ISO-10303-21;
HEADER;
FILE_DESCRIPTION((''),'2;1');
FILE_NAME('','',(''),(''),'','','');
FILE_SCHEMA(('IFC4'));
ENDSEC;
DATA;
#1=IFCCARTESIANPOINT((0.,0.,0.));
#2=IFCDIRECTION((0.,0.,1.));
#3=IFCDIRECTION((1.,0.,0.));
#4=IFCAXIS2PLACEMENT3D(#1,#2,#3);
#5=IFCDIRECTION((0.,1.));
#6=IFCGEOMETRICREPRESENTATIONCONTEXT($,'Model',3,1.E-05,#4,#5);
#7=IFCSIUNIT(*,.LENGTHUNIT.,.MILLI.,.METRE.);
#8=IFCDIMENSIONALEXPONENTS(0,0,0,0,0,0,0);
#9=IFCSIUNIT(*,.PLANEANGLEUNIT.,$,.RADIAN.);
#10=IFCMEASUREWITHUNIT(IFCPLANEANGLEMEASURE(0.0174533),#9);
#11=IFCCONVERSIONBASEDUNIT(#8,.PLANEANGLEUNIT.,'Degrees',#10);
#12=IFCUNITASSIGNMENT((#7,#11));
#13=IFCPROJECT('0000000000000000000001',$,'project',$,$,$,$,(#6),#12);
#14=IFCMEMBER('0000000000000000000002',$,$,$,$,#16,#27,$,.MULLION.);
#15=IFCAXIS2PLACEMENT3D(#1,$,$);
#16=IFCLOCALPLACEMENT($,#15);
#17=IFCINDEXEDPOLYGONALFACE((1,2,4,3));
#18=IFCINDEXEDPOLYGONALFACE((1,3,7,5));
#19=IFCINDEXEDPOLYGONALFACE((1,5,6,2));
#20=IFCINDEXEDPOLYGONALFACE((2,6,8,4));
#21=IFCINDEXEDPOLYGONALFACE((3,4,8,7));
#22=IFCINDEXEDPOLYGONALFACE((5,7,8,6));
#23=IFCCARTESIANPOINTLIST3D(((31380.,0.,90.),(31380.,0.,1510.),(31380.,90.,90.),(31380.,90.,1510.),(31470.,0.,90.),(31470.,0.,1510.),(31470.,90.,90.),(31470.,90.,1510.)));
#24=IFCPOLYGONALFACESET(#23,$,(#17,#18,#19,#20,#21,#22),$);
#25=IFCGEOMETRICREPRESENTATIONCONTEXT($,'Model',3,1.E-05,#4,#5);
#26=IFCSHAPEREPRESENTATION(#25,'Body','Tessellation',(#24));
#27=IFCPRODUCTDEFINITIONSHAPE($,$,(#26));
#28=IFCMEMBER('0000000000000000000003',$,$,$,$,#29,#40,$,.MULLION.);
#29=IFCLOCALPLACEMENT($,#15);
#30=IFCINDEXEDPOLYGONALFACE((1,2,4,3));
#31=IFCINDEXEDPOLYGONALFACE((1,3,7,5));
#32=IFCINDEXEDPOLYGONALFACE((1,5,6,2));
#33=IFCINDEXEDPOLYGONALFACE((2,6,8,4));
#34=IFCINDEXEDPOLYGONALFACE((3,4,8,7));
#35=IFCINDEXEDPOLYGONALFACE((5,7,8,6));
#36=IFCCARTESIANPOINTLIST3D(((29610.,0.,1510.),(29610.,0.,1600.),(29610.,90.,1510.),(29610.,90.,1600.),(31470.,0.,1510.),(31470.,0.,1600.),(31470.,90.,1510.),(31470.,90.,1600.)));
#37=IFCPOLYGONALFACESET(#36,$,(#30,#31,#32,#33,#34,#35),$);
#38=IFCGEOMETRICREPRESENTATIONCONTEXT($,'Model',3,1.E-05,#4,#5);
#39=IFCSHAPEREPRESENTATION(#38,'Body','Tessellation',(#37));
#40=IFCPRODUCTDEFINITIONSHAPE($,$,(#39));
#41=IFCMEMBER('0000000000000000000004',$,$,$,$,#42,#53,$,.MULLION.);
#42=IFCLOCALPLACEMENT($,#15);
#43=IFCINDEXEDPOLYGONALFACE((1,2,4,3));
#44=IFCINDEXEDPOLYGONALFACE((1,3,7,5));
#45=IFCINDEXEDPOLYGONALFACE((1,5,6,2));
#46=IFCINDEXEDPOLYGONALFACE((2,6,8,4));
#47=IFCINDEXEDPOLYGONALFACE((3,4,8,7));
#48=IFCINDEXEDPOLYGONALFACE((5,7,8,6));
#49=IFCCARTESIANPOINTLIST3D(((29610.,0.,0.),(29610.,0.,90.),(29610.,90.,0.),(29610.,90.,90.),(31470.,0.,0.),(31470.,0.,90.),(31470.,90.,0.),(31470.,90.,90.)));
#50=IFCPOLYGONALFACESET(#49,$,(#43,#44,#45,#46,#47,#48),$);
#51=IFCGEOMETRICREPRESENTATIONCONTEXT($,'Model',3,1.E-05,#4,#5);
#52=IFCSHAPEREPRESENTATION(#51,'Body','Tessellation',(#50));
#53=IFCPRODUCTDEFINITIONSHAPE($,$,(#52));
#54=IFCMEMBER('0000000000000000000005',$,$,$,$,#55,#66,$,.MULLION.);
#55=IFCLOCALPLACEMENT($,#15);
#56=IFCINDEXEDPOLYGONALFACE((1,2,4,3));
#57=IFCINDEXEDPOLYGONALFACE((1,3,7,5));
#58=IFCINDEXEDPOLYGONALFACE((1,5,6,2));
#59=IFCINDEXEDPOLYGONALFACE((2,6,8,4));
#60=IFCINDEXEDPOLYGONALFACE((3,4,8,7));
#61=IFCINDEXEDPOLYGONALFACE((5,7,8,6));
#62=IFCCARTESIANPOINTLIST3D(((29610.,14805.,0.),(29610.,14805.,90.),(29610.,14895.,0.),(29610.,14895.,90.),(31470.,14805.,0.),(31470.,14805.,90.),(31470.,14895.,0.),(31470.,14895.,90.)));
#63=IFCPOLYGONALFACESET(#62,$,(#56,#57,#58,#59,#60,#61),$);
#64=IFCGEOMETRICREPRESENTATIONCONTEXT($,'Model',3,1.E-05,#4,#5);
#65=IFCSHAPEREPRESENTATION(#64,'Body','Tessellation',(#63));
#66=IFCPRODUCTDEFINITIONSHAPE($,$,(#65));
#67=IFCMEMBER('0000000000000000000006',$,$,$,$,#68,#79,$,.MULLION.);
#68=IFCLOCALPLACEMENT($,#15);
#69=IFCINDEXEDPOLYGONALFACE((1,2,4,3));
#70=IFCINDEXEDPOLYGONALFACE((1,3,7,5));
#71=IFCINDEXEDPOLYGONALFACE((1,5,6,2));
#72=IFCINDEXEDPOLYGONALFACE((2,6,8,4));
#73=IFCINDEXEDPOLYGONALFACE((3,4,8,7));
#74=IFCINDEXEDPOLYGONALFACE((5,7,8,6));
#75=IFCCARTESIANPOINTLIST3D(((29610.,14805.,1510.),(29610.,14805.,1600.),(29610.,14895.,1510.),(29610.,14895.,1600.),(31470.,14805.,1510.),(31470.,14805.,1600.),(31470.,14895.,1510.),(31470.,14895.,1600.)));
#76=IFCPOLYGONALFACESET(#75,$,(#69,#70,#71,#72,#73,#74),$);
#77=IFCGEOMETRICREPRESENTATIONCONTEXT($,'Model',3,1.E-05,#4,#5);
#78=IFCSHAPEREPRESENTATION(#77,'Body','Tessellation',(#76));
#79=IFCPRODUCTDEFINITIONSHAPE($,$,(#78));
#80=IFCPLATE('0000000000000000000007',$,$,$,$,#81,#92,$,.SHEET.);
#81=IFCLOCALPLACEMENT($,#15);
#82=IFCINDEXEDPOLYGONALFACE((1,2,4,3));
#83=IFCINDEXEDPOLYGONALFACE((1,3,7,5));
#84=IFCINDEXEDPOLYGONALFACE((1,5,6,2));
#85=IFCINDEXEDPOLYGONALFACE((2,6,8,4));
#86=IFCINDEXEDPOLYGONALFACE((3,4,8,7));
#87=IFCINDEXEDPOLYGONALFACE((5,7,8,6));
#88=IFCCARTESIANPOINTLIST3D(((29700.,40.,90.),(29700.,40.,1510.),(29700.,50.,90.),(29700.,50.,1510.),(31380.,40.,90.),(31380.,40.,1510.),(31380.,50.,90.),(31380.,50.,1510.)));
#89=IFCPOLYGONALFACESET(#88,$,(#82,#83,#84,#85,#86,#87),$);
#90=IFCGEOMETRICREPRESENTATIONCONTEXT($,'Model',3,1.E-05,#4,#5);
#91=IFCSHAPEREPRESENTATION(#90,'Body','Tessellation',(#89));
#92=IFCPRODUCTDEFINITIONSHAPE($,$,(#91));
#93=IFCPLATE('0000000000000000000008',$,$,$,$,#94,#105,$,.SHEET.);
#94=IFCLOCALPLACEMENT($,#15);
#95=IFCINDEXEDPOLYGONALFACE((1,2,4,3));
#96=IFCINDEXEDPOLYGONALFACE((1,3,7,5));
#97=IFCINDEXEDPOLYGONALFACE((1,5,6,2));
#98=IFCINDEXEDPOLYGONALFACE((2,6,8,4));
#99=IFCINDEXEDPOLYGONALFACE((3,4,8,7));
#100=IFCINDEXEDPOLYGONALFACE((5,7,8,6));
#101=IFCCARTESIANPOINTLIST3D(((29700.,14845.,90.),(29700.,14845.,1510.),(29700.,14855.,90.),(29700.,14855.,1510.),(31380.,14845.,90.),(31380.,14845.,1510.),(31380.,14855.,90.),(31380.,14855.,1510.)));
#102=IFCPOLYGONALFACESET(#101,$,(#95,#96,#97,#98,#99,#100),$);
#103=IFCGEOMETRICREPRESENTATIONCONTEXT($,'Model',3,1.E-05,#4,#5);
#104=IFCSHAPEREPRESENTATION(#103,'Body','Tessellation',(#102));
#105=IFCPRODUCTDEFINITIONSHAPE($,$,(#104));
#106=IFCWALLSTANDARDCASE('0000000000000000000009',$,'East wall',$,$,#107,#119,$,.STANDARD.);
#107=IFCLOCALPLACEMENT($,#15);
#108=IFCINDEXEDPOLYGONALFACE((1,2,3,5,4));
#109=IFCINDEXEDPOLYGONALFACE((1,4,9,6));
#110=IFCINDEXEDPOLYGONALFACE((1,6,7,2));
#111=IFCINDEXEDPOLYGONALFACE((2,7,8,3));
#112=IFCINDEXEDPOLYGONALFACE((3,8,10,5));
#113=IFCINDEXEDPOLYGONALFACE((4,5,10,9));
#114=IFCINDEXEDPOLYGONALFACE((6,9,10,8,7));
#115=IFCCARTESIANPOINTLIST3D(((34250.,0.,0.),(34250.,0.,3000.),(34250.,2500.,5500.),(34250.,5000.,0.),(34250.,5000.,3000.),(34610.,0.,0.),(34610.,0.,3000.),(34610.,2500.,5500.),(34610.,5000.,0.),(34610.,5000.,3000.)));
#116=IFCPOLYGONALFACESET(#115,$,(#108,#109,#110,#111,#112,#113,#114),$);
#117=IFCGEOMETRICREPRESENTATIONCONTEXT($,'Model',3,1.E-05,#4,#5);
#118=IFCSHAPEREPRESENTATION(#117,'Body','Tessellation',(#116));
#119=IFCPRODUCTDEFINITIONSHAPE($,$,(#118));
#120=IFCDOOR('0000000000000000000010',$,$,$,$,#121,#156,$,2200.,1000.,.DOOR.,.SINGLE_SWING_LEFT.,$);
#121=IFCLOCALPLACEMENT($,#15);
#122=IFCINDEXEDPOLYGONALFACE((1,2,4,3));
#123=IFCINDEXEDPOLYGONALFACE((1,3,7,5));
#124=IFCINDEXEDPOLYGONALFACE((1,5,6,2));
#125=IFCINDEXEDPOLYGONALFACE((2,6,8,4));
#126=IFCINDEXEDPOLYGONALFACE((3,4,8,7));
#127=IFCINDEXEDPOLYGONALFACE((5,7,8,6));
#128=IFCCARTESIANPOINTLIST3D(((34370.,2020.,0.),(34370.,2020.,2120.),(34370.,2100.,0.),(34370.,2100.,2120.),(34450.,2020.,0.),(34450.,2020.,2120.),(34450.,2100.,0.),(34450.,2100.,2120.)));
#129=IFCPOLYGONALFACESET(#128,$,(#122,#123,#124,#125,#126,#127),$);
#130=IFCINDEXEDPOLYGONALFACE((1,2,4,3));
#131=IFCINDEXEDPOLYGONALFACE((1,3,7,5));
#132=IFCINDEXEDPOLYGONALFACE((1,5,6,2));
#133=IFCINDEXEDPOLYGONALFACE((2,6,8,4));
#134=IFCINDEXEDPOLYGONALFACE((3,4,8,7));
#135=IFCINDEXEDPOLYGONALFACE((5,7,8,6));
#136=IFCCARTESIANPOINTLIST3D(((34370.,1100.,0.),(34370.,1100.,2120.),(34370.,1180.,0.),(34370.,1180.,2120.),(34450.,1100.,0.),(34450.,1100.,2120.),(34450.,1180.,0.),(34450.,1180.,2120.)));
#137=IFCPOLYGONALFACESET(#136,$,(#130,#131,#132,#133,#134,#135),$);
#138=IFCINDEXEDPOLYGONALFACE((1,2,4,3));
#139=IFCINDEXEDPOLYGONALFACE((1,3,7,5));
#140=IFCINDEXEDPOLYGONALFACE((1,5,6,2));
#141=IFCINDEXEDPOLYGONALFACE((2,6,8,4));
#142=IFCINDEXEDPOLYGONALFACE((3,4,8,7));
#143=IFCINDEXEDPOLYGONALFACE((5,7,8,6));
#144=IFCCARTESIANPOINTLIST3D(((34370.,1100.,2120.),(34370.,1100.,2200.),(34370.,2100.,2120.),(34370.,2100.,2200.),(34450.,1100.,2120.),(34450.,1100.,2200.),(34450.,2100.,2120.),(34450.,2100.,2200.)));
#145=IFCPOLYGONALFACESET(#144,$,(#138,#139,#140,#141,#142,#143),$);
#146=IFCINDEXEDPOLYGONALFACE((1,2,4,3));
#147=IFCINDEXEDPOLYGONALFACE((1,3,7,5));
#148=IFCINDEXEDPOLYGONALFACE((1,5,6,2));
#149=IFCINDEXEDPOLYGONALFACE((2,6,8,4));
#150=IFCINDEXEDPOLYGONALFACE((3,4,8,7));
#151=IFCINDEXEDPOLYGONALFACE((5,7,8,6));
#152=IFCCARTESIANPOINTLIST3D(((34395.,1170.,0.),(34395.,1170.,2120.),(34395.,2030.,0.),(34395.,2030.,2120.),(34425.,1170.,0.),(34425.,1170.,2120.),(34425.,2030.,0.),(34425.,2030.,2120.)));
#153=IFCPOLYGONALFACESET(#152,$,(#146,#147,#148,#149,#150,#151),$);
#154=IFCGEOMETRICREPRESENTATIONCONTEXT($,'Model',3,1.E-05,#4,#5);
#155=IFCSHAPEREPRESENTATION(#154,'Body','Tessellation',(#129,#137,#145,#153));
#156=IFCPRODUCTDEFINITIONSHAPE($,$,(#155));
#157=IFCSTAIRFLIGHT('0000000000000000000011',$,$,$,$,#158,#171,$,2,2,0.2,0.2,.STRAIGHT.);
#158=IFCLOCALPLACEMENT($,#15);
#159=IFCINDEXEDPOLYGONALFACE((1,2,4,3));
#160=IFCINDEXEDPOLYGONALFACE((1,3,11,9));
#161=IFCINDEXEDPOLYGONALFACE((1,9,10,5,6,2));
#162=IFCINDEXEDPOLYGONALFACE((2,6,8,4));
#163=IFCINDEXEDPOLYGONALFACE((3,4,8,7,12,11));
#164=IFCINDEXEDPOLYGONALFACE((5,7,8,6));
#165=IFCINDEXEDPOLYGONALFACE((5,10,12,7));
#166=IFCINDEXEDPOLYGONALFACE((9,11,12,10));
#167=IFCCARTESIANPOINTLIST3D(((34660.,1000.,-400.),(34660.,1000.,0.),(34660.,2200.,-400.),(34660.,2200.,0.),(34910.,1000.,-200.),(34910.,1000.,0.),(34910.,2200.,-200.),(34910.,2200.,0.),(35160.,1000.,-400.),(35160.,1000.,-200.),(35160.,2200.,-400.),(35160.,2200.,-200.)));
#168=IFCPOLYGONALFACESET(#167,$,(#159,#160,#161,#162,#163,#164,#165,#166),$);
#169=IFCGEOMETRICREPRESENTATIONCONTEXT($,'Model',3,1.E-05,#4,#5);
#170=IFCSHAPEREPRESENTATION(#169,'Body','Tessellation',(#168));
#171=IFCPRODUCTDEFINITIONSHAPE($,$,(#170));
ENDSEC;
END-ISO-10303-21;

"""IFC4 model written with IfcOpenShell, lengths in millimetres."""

from ifc_helpers import new_model, entity, si_unit, converted_unit, direction, frame, origin_with_axes, place, context, project, polyline, outline, extrude, clip, halfspace, source, transform, mapped, element, save


model = new_model("IFC4")

# Units and contexts
model_context_1 = context("Model", 3, precision=1e-05, world=origin_with_axes(), true_north=direction((0.0, 1.0)))
model_context_2 = context("Model", 3, precision=1e-05, world=origin_with_axes(), true_north=direction((0.0, 1.0)))
model_context_3 = context("Model", 3, precision=1e-05, world=origin_with_axes(), true_north=direction((0.0, 1.0)))
model_context_4 = context("Model", 3, precision=1e-05, world=origin_with_axes(), true_north=direction((0.0, 1.0)))
model_context_5 = context("Model", 3, precision=1e-05, world=origin_with_axes(), true_north=direction((0.0, 1.0)))
model_context_6 = context("Model", 3, precision=1e-05, world=origin_with_axes(), true_north=direction((0.0, 1.0)))
model_context_7 = context("Model", 3, precision=1e-05, world=origin_with_axes(), true_north=direction((0.0, 1.0)))
model_context_8 = context("Model", 3, precision=1e-05, world=origin_with_axes(), true_north=direction((0.0, 1.0)))
model_context_9 = context("Model", 3, precision=1e-05, world=origin_with_axes(), true_north=direction((0.0, 1.0)))
model_context_10 = context("Model", 3, precision=1e-05, world=origin_with_axes(), true_north=direction((0.0, 1.0)))
model_context_11 = context("Model", 3, precision=1e-05, world=origin_with_axes(), true_north=direction((0.0, 1.0)))
ifc_project = project(units=[si_unit("LENGTHUNIT", "METRE", prefix="MILLI"), converted_unit("PLANEANGLEUNIT", "Degrees", entity("IfcPlaneAngleMeasure", 0.0174533), si_unit("PLANEANGLEUNIT", "RADIAN"), dimensions=[0, 0, 0, 0, 0, 0, 0])], contexts=[model_context_1])

# Members
shared_shape_1 = source(origin_with_axes(), model_context_3, "Body", "SweptSolid", [
    extrude(outline(polyline([(-45.0, -45.0), (45.0, -45.0), (45.0, 45.0), (-45.0, 45.0), (-45.0, -45.0), (-45.0, -45.0)])), origin_with_axes(), (0.0, 0.0, 1.0), 1420.0),
])
placement_1 = place(None, frame((29610.0, 0.0, 0.0)))
member_1_placement = place(placement_1, frame((1815.0, 45.0, 90.0), z_axis=(0.0, 0.0, 1.0), x_axis=(1.0, 0.0, 0.0)))
element("IfcMember", 1, at=member_1_placement, PredefinedType="MULLION", context=model_context_3, shape_type="MappedRepresentation", body=[
    mapped(shared_shape_1, transform((0.0, 0.0, 0.0))),
])
shared_shape_2 = source(origin_with_axes(), model_context_4, "Body", "SweptSolid", [
    extrude(outline(polyline([(-930.0, -45.0), (930.0, -45.0), (930.0, 45.0), (-930.0, 45.0), (-930.0, -45.0), (-930.0, -45.0)])), origin_with_axes(), (0.0, 0.0, 1.0), 90.0),
])
member_2_placement = place(placement_1, frame((930.0, 45.0, 1510.0), z_axis=(0.0, 0.0, 1.0), x_axis=(1.0, 0.0, 0.0)))
element("IfcMember", 2, at=member_2_placement, PredefinedType="MULLION", context=model_context_4, shape_type="MappedRepresentation", body=[
    mapped(shared_shape_2, transform((0.0, 0.0, 0.0))),
])
shared_shape_3 = source(origin_with_axes(), model_context_5, "Body", "SweptSolid", [
    extrude(outline(polyline([(-930.0, -45.0), (930.0, -45.0), (930.0, 45.0), (-930.0, 45.0), (-930.0, -45.0), (-930.0, -45.0)])), origin_with_axes(), (0.0, 0.0, 1.0), 90.0),
])
member_3_placement = place(placement_1, frame((930.0, 45.0, 0.0), z_axis=(0.0, 0.0, 1.0), x_axis=(1.0, 0.0, 0.0)))
element("IfcMember", 3, at=member_3_placement, PredefinedType="MULLION", context=model_context_5, shape_type="MappedRepresentation", body=[
    mapped(shared_shape_3, transform((0.0, 0.0, 0.0))),
])
shared_shape_4 = source(origin_with_axes(), model_context_9, "Body", "SweptSolid", [
    extrude(outline(polyline([(-930.0, -45.0), (930.0, -45.0), (930.0, 45.0), (-930.0, 45.0), (-930.0, -45.0), (-930.0, -45.0)])), origin_with_axes(), (0.0, 0.0, 1.0), 90.0),
])
placement_2 = place(None, frame((29610.0, 14805.0, 0.0)))
member_4_placement = place(placement_2, frame((930.0, 45.0, 0.0), z_axis=(0.0, 0.0, 1.0), x_axis=(1.0, 0.0, 0.0)))
element("IfcMember", 4, at=member_4_placement, PredefinedType="MULLION", context=model_context_9, shape_type="MappedRepresentation", body=[
    mapped(shared_shape_4, transform((0.0, 0.0, 0.0))),
])
shared_shape_5 = source(origin_with_axes(), model_context_10, "Body", "SweptSolid", [
    extrude(outline(polyline([(-930.0, -45.0), (930.0, -45.0), (930.0, 45.0), (-930.0, 45.0), (-930.0, -45.0), (-930.0, -45.0)])), origin_with_axes(), (0.0, 0.0, 1.0), 90.0),
])
member_5_placement = place(placement_2, frame((930.0, 45.0, 1510.0), z_axis=(0.0, 0.0, 1.0), x_axis=(1.0, 0.0, 0.0)))
element("IfcMember", 5, at=member_5_placement, PredefinedType="MULLION", context=model_context_10, shape_type="MappedRepresentation", body=[
    mapped(shared_shape_5, transform((0.0, 0.0, 0.0))),
])

# Plates
plate_1_placement = place(placement_1, frame((930.0, 45.0, 90.0), z_axis=(0.0, 0.0, 1.0), x_axis=(1.0, 0.0, 0.0)))
element("IfcPlate", 6, at=plate_1_placement, PredefinedType="SHEET", context=model_context_6, shape_type="SweptSolid", body=[
    extrude(outline(polyline([(-840.0, -5.0), (840.0, -5.0), (840.0, 5.0), (-840.0, 5.0), (-840.0, -5.0), (-840.0, -5.0)])), origin_with_axes(), (0.0, 0.0, 1.0), 1420.0),
])
plate_2_placement = place(placement_2, frame((930.0, 45.0, 90.0), z_axis=(0.0, 0.0, 1.0), x_axis=(1.0, 0.0, 0.0)))
element("IfcPlate", 7, at=plate_2_placement, PredefinedType="SHEET", context=model_context_11, shape_type="SweptSolid", body=[
    extrude(outline(polyline([(-840.0, -5.0), (840.0, -5.0), (840.0, 5.0), (-840.0, 5.0), (-840.0, -5.0), (-840.0, -5.0)])), origin_with_axes(), (0.0, 0.0, 1.0), 1420.0),
])

# Wall
shared_shape_6 = source(origin_with_axes(), model_context_8, "Body", "Clipping", [
    clip(clip(extrude(outline(polyline([(-2500.0, -180.0), (2500.0, -180.0), (2500.0, 180.0), (-2500.0, 180.0), (-2500.0, -180.0), (-2500.0, -180.0)])), origin_with_axes(), (0.0, 0.0, 1.0), 6000.0), halfspace(frame((-2500.0, 0.0, 3000.0), z_axis=(-1.0, 0.0, 1.0), x_axis=(1.0, 0.0, 0.0)), False)), halfspace(frame((2500.0, 0.0, 3000.0), z_axis=(1.0, 0.0, 1.0), x_axis=(1.0, 0.0, 0.0)), False)),
])
wall_placement = place(placement_1, frame((4820.0, 2500.0, 0.0), z_axis=(0.0, 0.0, 1.0), x_axis=(0.0, 1.0, 0.0)))
element("IfcWallStandardCase", 8, at=wall_placement, Name="East wall", PredefinedType="STANDARD", context=model_context_8, shape_type="MappedRepresentation", body=[
    mapped(shared_shape_6, transform((0.0, 0.0, 0.0))),
])

# Door
door_placement = place(placement_1, frame((4800.0, 1600.0, 0.0), z_axis=(0.0, 0.0, 1.0), x_axis=(0.0, 1.0, 0.0)))
element("IfcDoor", 9, at=door_placement, OperationType="SINGLE_SWING_LEFT", OverallHeight=2200.0, OverallWidth=1000.0, PredefinedType="DOOR", context=model_context_2, shape_type="SweptSolid", body=[
    extrude(outline(polyline([(-40.0, -40.0), (40.0, -40.0), (40.0, 40.0), (-40.0, 40.0), (-40.0, -40.0), (-40.0, -40.0)])), frame((460.0, 0.0, 0.0), z_axis=(0.0, 0.0, 1.0), x_axis=(1.0, 0.0, 0.0)), (0.0, 0.0, 1.0), 2120.0),
    extrude(outline(polyline([(-40.0, -40.0), (40.0, -40.0), (40.0, 40.0), (-40.0, 40.0), (-40.0, -40.0), (-40.0, -40.0)])), frame((-460.0, 0.0, 0.0), z_axis=(0.0, 0.0, 1.0), x_axis=(1.0, 0.0, 0.0)), (0.0, 0.0, 1.0), 2120.0),
    extrude(outline(polyline([(-500.0, -40.0), (500.0, -40.0), (500.0, 40.0), (-500.0, 40.0), (-500.0, -40.0), (-500.0, -40.0)])), frame((0.0, 0.0, 2120.0), z_axis=(0.0, 0.0, 1.0), x_axis=(1.0, 0.0, 0.0)), (0.0, 0.0, 1.0), 80.0),
    extrude(outline(polyline([(-430.0, -15.0), (430.0, -15.0), (430.0, 15.0), (-430.0, 15.0), (-430.0, -15.0), (-430.0, -15.0)])), origin_with_axes(), (0.0, 0.0, 1.0), 2120.0),
])

# Stair flight
stair_flight_placement = place(placement_1, frame((5050.0, 1000.0, 0.0), z_axis=(0.0, 1.0, 0.0), x_axis=(1.0, 0.0, 0.0)))
element("IfcStairFlight", 10, at=stair_flight_placement, NumberOfRisers=2, NumberOfTreads=2, PredefinedType="STRAIGHT", RiserHeight=0.2, TreadLength=0.2, context=model_context_7, shape_type="SweptSolid", body=[
    extrude(outline(polyline([(0.0, 0.0), (250.0, 0.0), (250.0, 200.0), (500.0, 200.0), (500.0, 400.0), (0.0, 400.0), (0.0, 0.0)])), origin_with_axes(), (0.0, 0.0, 1.0), 1200.0),
])

save(model, "model.ifc")
